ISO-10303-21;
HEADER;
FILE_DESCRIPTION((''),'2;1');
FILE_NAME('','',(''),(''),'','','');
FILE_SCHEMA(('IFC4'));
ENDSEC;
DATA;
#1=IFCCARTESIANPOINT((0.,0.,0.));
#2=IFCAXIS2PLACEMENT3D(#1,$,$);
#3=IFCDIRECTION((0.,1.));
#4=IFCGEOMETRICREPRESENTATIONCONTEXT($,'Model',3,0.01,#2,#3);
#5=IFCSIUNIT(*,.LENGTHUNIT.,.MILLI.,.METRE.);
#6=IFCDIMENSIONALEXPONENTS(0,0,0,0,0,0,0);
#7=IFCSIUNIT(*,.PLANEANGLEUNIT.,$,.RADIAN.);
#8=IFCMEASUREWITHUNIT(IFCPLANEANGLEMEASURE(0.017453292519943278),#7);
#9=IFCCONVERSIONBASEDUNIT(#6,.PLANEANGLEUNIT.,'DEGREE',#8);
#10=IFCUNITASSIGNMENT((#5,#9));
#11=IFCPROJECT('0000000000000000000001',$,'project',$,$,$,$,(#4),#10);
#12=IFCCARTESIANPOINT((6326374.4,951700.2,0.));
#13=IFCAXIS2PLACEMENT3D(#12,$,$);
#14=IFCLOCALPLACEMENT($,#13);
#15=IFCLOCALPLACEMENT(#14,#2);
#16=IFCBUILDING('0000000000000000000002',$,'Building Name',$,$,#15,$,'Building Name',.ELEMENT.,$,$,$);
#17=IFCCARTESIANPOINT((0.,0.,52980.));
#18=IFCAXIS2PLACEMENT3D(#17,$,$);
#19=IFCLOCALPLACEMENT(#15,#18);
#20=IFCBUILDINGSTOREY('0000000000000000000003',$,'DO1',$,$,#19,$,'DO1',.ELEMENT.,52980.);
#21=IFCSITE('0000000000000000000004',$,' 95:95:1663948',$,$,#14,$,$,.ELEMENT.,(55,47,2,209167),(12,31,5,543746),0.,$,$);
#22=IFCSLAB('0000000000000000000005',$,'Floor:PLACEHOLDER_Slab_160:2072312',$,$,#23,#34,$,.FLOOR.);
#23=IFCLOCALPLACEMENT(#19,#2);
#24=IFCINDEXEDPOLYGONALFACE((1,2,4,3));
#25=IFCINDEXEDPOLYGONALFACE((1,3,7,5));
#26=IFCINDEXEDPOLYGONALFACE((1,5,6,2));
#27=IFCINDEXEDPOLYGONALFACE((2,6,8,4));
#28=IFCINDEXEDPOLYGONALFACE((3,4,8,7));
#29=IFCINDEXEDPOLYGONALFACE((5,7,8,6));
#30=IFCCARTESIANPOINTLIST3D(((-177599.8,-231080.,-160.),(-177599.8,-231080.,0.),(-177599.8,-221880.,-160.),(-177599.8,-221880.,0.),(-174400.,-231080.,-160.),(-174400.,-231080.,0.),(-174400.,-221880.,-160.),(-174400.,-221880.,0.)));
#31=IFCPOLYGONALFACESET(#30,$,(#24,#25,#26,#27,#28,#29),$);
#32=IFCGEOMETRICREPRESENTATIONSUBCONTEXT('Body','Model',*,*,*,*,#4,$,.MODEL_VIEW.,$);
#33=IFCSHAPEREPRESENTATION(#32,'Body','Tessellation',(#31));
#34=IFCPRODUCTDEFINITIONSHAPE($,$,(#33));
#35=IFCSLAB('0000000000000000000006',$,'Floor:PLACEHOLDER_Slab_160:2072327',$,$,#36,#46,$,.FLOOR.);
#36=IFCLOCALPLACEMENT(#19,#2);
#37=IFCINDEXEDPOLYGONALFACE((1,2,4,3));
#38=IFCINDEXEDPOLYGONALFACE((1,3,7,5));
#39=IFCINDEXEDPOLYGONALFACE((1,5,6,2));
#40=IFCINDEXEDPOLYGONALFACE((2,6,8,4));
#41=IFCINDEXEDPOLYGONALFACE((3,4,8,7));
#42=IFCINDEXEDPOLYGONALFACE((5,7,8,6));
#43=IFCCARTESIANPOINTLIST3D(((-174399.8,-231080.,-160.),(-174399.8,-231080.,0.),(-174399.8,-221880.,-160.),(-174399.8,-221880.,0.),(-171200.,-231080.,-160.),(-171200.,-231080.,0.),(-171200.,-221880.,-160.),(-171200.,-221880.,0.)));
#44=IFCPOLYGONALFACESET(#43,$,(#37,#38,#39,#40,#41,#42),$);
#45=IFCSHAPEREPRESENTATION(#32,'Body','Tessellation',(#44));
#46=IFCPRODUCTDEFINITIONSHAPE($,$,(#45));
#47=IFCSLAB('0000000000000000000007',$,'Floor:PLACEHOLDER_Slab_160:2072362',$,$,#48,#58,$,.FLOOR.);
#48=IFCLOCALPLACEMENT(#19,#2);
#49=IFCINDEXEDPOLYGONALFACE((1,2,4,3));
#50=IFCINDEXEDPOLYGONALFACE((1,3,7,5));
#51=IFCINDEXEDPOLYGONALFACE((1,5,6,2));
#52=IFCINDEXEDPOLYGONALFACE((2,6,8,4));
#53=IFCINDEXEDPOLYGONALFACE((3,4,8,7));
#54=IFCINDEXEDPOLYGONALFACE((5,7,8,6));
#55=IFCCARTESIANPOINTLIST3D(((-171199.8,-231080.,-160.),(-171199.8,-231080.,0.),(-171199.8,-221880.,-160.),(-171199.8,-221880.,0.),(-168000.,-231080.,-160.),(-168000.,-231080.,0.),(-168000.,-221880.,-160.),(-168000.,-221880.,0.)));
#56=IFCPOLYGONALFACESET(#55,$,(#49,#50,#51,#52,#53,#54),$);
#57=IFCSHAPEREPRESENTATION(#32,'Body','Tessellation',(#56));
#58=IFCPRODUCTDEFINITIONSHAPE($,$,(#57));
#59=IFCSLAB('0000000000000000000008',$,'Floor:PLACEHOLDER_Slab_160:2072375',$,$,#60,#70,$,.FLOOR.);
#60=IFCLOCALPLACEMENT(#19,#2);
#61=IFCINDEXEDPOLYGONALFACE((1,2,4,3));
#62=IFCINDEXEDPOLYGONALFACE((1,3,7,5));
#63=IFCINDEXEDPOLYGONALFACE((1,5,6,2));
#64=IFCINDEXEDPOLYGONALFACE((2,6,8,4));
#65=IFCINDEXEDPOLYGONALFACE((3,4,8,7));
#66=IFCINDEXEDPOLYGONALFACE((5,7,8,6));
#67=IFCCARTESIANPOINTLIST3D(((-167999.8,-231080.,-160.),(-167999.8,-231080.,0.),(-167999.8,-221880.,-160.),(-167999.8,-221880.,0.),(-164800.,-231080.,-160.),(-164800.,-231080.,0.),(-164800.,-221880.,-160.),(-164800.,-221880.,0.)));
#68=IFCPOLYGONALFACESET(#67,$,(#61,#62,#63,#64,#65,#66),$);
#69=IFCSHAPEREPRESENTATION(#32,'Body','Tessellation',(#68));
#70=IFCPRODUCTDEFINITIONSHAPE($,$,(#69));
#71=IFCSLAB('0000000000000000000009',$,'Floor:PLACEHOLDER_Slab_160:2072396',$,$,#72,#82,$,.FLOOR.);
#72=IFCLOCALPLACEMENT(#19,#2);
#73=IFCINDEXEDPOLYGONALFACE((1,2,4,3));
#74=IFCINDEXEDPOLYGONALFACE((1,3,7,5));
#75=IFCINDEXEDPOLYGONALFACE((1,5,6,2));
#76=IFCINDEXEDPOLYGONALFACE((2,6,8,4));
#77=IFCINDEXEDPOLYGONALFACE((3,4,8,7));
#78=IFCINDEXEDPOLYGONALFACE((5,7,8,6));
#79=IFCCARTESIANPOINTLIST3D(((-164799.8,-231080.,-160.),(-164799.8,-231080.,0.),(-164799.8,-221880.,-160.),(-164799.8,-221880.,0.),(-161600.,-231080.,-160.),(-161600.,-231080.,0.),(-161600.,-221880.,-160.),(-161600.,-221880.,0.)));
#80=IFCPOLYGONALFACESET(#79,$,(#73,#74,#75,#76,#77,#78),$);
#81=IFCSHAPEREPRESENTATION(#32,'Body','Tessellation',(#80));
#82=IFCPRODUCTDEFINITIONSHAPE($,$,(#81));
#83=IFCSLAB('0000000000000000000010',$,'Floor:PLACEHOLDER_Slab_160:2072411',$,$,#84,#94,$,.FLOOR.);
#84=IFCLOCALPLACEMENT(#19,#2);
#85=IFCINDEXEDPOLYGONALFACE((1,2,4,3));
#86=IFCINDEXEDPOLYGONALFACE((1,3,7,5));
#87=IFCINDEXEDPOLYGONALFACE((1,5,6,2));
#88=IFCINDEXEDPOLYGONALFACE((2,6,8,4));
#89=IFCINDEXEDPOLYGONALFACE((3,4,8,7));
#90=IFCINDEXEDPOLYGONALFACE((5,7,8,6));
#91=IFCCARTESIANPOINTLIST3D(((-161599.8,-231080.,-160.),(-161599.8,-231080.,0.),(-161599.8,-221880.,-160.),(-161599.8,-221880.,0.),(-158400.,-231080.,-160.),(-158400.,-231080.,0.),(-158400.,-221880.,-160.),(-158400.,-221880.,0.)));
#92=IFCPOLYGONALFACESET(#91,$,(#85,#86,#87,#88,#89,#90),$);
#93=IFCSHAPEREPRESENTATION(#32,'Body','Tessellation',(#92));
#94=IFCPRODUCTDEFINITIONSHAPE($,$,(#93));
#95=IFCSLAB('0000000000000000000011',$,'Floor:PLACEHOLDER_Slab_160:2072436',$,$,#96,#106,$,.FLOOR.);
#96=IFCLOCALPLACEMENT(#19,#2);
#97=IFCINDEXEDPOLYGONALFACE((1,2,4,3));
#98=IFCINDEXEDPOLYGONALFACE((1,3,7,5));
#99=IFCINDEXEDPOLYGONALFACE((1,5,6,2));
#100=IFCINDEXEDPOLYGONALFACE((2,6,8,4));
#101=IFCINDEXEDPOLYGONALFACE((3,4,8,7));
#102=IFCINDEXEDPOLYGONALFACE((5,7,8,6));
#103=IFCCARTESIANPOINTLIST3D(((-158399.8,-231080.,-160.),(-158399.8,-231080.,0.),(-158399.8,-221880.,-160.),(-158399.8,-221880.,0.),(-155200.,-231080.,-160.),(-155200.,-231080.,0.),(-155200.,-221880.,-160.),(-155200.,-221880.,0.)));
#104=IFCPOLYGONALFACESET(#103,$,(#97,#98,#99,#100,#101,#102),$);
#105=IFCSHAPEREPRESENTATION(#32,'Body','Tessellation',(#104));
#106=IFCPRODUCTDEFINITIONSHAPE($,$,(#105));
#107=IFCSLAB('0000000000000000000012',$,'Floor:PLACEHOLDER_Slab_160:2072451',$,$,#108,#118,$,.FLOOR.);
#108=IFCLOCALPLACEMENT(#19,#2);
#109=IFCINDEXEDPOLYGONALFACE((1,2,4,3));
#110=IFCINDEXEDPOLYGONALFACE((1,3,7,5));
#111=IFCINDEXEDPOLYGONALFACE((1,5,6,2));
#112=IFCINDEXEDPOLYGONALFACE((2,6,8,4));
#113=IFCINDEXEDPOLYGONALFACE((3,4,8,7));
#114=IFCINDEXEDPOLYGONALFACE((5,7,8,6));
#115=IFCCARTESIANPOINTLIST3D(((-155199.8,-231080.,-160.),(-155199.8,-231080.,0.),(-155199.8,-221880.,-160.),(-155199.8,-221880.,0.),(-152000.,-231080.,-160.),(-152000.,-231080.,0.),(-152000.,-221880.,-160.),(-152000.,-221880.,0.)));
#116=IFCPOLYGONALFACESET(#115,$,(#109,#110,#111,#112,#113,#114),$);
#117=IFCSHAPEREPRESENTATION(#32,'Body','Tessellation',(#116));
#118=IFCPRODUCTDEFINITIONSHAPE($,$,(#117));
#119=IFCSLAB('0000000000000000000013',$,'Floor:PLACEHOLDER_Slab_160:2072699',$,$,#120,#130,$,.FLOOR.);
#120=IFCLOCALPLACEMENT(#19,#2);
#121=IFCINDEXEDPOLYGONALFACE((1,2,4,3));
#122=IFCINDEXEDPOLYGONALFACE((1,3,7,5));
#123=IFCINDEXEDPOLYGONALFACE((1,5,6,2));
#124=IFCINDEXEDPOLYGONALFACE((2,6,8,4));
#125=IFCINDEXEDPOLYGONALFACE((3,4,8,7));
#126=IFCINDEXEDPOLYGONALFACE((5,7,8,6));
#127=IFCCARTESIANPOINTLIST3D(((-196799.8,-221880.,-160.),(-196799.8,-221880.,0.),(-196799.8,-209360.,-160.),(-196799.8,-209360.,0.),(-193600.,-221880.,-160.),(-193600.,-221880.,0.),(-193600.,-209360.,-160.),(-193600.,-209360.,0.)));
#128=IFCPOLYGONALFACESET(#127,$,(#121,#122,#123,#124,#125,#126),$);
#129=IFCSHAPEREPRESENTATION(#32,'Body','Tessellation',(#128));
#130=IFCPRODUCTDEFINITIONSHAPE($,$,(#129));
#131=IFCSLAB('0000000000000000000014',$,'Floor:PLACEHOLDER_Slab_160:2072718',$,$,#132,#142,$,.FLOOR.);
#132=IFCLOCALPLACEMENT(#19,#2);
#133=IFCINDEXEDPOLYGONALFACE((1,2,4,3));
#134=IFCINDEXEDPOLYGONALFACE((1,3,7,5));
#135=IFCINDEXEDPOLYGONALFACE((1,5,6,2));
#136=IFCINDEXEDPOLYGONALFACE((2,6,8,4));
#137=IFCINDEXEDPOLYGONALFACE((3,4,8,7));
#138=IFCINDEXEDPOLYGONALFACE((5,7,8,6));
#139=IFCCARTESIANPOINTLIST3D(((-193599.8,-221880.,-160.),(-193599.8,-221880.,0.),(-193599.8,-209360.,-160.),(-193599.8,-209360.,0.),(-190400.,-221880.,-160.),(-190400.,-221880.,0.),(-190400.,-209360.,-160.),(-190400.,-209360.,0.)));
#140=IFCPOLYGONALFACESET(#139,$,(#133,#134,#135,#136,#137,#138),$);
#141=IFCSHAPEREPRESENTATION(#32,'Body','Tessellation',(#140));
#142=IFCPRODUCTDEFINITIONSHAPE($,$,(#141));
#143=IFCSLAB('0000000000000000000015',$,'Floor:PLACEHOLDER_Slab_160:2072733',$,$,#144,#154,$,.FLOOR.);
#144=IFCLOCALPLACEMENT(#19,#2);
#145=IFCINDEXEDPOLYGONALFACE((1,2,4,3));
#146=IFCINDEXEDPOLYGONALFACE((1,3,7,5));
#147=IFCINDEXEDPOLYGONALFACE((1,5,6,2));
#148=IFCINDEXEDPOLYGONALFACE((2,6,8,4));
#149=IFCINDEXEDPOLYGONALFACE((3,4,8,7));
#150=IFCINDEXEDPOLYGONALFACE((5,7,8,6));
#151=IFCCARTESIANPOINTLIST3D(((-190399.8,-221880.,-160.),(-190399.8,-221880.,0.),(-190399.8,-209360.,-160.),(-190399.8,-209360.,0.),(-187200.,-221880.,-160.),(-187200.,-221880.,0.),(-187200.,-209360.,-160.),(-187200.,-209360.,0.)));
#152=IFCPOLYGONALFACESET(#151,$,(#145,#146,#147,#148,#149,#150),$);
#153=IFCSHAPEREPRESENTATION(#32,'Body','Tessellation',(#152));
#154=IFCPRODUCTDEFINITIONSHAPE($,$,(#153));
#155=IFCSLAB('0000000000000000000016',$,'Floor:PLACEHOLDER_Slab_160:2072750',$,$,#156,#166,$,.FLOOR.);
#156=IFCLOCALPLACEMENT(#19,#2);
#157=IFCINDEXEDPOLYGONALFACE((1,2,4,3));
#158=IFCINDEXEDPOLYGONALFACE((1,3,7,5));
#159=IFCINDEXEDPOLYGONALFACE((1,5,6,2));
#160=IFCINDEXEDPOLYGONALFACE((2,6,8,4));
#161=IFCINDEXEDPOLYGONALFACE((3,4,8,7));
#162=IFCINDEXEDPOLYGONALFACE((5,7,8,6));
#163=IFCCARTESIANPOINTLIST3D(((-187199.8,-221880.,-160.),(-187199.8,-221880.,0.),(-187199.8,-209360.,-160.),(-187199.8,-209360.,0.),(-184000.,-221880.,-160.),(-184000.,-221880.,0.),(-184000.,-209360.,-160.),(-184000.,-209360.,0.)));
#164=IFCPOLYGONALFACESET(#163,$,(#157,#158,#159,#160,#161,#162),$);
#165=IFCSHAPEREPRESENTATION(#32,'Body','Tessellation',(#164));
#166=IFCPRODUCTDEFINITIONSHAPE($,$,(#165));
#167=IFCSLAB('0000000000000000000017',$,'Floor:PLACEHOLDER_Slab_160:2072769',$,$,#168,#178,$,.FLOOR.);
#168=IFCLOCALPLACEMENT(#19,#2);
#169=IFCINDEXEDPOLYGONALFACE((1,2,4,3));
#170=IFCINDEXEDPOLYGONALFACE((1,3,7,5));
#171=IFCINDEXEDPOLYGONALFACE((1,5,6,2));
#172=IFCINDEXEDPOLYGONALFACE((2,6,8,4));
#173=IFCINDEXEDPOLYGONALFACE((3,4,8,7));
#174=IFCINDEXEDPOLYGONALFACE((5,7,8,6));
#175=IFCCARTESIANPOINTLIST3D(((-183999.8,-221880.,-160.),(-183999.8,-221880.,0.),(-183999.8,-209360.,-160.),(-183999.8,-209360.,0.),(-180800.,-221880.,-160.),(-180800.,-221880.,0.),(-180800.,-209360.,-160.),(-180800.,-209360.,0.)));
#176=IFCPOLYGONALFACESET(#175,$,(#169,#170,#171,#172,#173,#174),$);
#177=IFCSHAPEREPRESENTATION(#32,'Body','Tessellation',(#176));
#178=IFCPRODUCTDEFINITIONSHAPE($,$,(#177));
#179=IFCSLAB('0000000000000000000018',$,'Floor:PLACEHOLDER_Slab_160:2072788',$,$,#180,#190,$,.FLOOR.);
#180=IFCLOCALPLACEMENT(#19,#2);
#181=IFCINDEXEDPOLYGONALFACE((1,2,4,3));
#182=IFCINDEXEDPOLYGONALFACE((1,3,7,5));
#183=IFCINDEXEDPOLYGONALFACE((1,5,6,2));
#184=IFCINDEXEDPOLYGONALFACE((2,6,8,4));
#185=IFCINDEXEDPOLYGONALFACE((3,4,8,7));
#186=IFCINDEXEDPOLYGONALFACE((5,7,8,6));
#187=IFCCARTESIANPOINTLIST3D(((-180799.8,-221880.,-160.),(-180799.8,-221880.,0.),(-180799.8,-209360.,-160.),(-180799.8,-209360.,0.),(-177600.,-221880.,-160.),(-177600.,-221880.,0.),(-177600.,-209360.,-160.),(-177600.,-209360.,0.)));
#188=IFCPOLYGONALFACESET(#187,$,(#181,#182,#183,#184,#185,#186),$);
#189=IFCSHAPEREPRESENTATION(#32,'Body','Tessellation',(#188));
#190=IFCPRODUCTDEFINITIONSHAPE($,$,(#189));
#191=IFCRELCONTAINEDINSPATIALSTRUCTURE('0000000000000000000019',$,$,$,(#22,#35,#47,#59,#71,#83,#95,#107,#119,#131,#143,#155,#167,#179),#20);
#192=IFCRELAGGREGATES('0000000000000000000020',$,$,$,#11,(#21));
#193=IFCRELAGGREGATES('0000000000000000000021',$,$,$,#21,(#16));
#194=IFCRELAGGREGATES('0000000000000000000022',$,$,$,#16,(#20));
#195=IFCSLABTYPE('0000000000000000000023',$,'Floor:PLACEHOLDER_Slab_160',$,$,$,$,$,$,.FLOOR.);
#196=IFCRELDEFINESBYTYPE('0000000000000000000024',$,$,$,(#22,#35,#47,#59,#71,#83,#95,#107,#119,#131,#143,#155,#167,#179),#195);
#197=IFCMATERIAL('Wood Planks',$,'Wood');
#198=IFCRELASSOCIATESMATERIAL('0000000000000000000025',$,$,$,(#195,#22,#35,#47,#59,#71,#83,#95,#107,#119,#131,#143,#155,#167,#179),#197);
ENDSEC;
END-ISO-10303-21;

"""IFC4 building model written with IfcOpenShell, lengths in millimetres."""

from ifc_helpers import new_model, entity, si_unit, converted_unit, direction, frame, origin, place, context, subcontext, project, spatial, indexed_curve, outline, extrude, material, type_object, element, save


model = new_model("IFC4")

# Units and contexts
model_context = context("Model", 3, precision=0.01, world=origin(), true_north=direction((0.0, 1.0)))
body_context = subcontext(model_context, "Body", "Model", "MODEL_VIEW")
ifc_project = project(units=[si_unit("LENGTHUNIT", "METRE", prefix="MILLI"), converted_unit("PLANEANGLEUNIT", "DEGREE", entity("IfcPlaneAngleMeasure", 0.017453292519943278), si_unit("PLANEANGLEUNIT", "RADIAN"), dimensions=[0, 0, 0, 0, 0, 0, 0])], contexts=[model_context])

# Site, building, storey
site_placement = place(None, frame((6326374.4, 951700.2, 0.0)))
site = spatial("IfcSite", under=ifc_project, at=site_placement, Name=" 95:95:1663948", CompositionType="ELEMENT", RefLatitude=(55, 47, 2, 209167), RefLongitude=(12, 31, 5, 543746), RefElevation=0.0)
building_placement = place(site_placement, origin())
building = spatial("IfcBuilding", under=site, at=building_placement, Name="Building Name", LongName="Building Name", CompositionType="ELEMENT")
storey_placement = place(building_placement, frame((0.0, 0.0, 52980.0)))
storey = spatial("IfcBuildingStorey", under=building, at=storey_placement, Name="DO1", LongName="DO1", CompositionType="ELEMENT", Elevation=52980.0)

# Slabs
ifc_material = material(Name="Wood Planks", Category="Wood")
slab_type = type_object("IfcSlabType", Name="Floor:PLACEHOLDER_Slab_160", PredefinedType="FLOOR", material=ifc_material)
slab_1_placement = place(storey_placement, origin())
element("IfcSlab", 1, at=slab_1_placement, inside=storey, type_object=slab_type, material=ifc_material, Name="Floor:PLACEHOLDER_Slab_160:2072312", PredefinedType="FLOOR", context=body_context, shape_type="SweptSolid", body=[
    extrude(outline(indexed_curve([(-4600.0, -1599.9), (4600.0, -1599.9), (4600.0, 1599.9), (-4600.0, 1599.9), (-4600.0, -1599.9)], self_intersect=False)), frame((-175999.9, -226480.0, 0.0), z_axis=(0.0, 0.0, -1.0), x_axis=(0.0, 1.0, 0.0)), (0.0, 0.0, 1.0), 160.0),
])
slab_2_placement = place(storey_placement, origin())
element("IfcSlab", 2, at=slab_2_placement, inside=storey, type_object=slab_type, material=ifc_material, Name="Floor:PLACEHOLDER_Slab_160:2072327", PredefinedType="FLOOR", context=body_context, shape_type="SweptSolid", body=[
    extrude(outline(indexed_curve([(-4600.0, -1599.9), (4600.0, -1599.9), (4600.0, 1599.9), (-4600.0, 1599.9), (-4600.0, -1599.9)], self_intersect=False)), frame((-172799.9, -226480.0, 0.0), z_axis=(0.0, 0.0, -1.0), x_axis=(0.0, 1.0, 0.0)), (0.0, 0.0, 1.0), 160.0),
])
slab_3_placement = place(storey_placement, origin())
element("IfcSlab", 3, at=slab_3_placement, inside=storey, type_object=slab_type, material=ifc_material, Name="Floor:PLACEHOLDER_Slab_160:2072362", PredefinedType="FLOOR", context=body_context, shape_type="SweptSolid", body=[
    extrude(outline(indexed_curve([(-4600.0, -1599.9), (4600.0, -1599.9), (4600.0, 1599.9), (-4600.0, 1599.9), (-4600.0, -1599.9)], self_intersect=False)), frame((-169599.9, -226480.0, 0.0), z_axis=(0.0, 0.0, -1.0), x_axis=(0.0, 1.0, 0.0)), (0.0, 0.0, 1.0), 160.0),
])
slab_4_placement = place(storey_placement, origin())
element("IfcSlab", 4, at=slab_4_placement, inside=storey, type_object=slab_type, material=ifc_material, Name="Floor:PLACEHOLDER_Slab_160:2072375", PredefinedType="FLOOR", context=body_context, shape_type="SweptSolid", body=[
    extrude(outline(indexed_curve([(-4600.0, -1599.9), (4600.0, -1599.9), (4600.0, 1599.9), (-4600.0, 1599.9), (-4600.0, -1599.9)], self_intersect=False)), frame((-166399.9, -226480.0, 0.0), z_axis=(0.0, 0.0, -1.0), x_axis=(0.0, 1.0, 0.0)), (0.0, 0.0, 1.0), 160.0),
])
slab_5_placement = place(storey_placement, origin())
element("IfcSlab", 5, at=slab_5_placement, inside=storey, type_object=slab_type, material=ifc_material, Name="Floor:PLACEHOLDER_Slab_160:2072396", PredefinedType="FLOOR", context=body_context, shape_type="SweptSolid", body=[
    extrude(outline(indexed_curve([(-4600.0, -1599.9), (4600.0, -1599.9), (4600.0, 1599.9), (-4600.0, 1599.9), (-4600.0, -1599.9)], self_intersect=False)), frame((-163199.9, -226480.0, 0.0), z_axis=(0.0, 0.0, -1.0), x_axis=(0.0, 1.0, 0.0)), (0.0, 0.0, 1.0), 160.0),
])
slab_6_placement = place(storey_placement, origin())
element("IfcSlab", 6, at=slab_6_placement, inside=storey, type_object=slab_type, material=ifc_material, Name="Floor:PLACEHOLDER_Slab_160:2072411", PredefinedType="FLOOR", context=body_context, shape_type="SweptSolid", body=[
    extrude(outline(indexed_curve([(-4600.0, -1599.9), (4600.0, -1599.9), (4600.0, 1599.9), (-4600.0, 1599.9), (-4600.0, -1599.9)], self_intersect=False)), frame((-159999.9, -226480.0, 0.0), z_axis=(0.0, 0.0, -1.0), x_axis=(0.0, 1.0, 0.0)), (0.0, 0.0, 1.0), 160.0),
])
slab_7_placement = place(storey_placement, origin())
element("IfcSlab", 7, at=slab_7_placement, inside=storey, type_object=slab_type, material=ifc_material, Name="Floor:PLACEHOLDER_Slab_160:2072436", PredefinedType="FLOOR", context=body_context, shape_type="SweptSolid", body=[
    extrude(outline(indexed_curve([(-4600.0, -1599.9), (4600.0, -1599.9), (4600.0, 1599.9), (-4600.0, 1599.9), (-4600.0, -1599.9)], self_intersect=False)), frame((-156799.9, -226480.0, 0.0), z_axis=(0.0, 0.0, -1.0), x_axis=(0.0, 1.0, 0.0)), (0.0, 0.0, 1.0), 160.0),
])
slab_8_placement = place(storey_placement, origin())
element("IfcSlab", 8, at=slab_8_placement, inside=storey, type_object=slab_type, material=ifc_material, Name="Floor:PLACEHOLDER_Slab_160:2072451", PredefinedType="FLOOR", context=body_context, shape_type="SweptSolid", body=[
    extrude(outline(indexed_curve([(-4600.0, -1599.9), (4600.0, -1599.9), (4600.0, 1599.9), (-4600.0, 1599.9), (-4600.0, -1599.9)], self_intersect=False)), frame((-153599.9, -226480.0, 0.0), z_axis=(0.0, 0.0, -1.0), x_axis=(0.0, 1.0, 0.0)), (0.0, 0.0, 1.0), 160.0),
])
slab_9_placement = place(storey_placement, origin())
element("IfcSlab", 9, at=slab_9_placement, inside=storey, type_object=slab_type, material=ifc_material, Name="Floor:PLACEHOLDER_Slab_160:2072699", PredefinedType="FLOOR", context=body_context, shape_type="SweptSolid", body=[
    extrude(outline(indexed_curve([(-6260.0, -1599.9), (6260.0, -1599.9), (6260.0, 1599.9), (-6260.0, 1599.9), (-6260.0, -1599.9)], self_intersect=False)), frame((-195199.9, -215620.0, 0.0), z_axis=(0.0, 0.0, -1.0), x_axis=(0.0, 1.0, 0.0)), (0.0, 0.0, 1.0), 160.0),
])
slab_10_placement = place(storey_placement, origin())
element("IfcSlab", 10, at=slab_10_placement, inside=storey, type_object=slab_type, material=ifc_material, Name="Floor:PLACEHOLDER_Slab_160:2072718", PredefinedType="FLOOR", context=body_context, shape_type="SweptSolid", body=[
    extrude(outline(indexed_curve([(-6260.0, -1599.9), (6260.0, -1599.9), (6260.0, 1599.9), (-6260.0, 1599.9), (-6260.0, -1599.9)], self_intersect=False)), frame((-191999.9, -215620.0, 0.0), z_axis=(0.0, 0.0, -1.0), x_axis=(0.0, 1.0, 0.0)), (0.0, 0.0, 1.0), 160.0),
])
slab_11_placement = place(storey_placement, origin())
element("IfcSlab", 11, at=slab_11_placement, inside=storey, type_object=slab_type, material=ifc_material, Name="Floor:PLACEHOLDER_Slab_160:2072733", PredefinedType="FLOOR", context=body_context, shape_type="SweptSolid", body=[
    extrude(outline(indexed_curve([(-6260.0, -1599.9), (6260.0, -1599.9), (6260.0, 1599.9), (-6260.0, 1599.9), (-6260.0, -1599.9)], self_intersect=False)), frame((-188799.9, -215620.0, 0.0), z_axis=(0.0, 0.0, -1.0), x_axis=(0.0, 1.0, 0.0)), (0.0, 0.0, 1.0), 160.0),
])
slab_12_placement = place(storey_placement, origin())
element("IfcSlab", 12, at=slab_12_placement, inside=storey, type_object=slab_type, material=ifc_material, Name="Floor:PLACEHOLDER_Slab_160:2072750", PredefinedType="FLOOR", context=body_context, shape_type="SweptSolid", body=[
    extrude(outline(indexed_curve([(-6260.0, -1599.9), (6260.0, -1599.9), (6260.0, 1599.9), (-6260.0, 1599.9), (-6260.0, -1599.9)], self_intersect=False)), frame((-185599.9, -215620.0, 0.0), z_axis=(0.0, 0.0, -1.0), x_axis=(0.0, 1.0, 0.0)), (0.0, 0.0, 1.0), 160.0),
])
slab_13_placement = place(storey_placement, origin())
element("IfcSlab", 13, at=slab_13_placement, inside=storey, type_object=slab_type, material=ifc_material, Name="Floor:PLACEHOLDER_Slab_160:2072769", PredefinedType="FLOOR", context=body_context, shape_type="SweptSolid", body=[
    extrude(outline(indexed_curve([(-6260.0, -1599.9), (6260.0, -1599.9), (6260.0, 1599.9), (-6260.0, 1599.9), (-6260.0, -1599.9)], self_intersect=False)), frame((-182399.9, -215620.0, 0.0), z_axis=(0.0, 0.0, -1.0), x_axis=(0.0, 1.0, 0.0)), (0.0, 0.0, 1.0), 160.0),
])
slab_14_placement = place(storey_placement, origin())
element("IfcSlab", 14, at=slab_14_placement, inside=storey, type_object=slab_type, material=ifc_material, Name="Floor:PLACEHOLDER_Slab_160:2072788", PredefinedType="FLOOR", context=body_context, shape_type="SweptSolid", body=[
    extrude(outline(indexed_curve([(-6260.0, -1599.9), (6260.0, -1599.9), (6260.0, 1599.9), (-6260.0, 1599.9), (-6260.0, -1599.9)], self_intersect=False)), frame((-179199.9, -215620.0, 0.0), z_axis=(0.0, 0.0, -1.0), x_axis=(0.0, 1.0, 0.0)), (0.0, 0.0, 1.0), 160.0),
])

save(model, "model.ifc")
